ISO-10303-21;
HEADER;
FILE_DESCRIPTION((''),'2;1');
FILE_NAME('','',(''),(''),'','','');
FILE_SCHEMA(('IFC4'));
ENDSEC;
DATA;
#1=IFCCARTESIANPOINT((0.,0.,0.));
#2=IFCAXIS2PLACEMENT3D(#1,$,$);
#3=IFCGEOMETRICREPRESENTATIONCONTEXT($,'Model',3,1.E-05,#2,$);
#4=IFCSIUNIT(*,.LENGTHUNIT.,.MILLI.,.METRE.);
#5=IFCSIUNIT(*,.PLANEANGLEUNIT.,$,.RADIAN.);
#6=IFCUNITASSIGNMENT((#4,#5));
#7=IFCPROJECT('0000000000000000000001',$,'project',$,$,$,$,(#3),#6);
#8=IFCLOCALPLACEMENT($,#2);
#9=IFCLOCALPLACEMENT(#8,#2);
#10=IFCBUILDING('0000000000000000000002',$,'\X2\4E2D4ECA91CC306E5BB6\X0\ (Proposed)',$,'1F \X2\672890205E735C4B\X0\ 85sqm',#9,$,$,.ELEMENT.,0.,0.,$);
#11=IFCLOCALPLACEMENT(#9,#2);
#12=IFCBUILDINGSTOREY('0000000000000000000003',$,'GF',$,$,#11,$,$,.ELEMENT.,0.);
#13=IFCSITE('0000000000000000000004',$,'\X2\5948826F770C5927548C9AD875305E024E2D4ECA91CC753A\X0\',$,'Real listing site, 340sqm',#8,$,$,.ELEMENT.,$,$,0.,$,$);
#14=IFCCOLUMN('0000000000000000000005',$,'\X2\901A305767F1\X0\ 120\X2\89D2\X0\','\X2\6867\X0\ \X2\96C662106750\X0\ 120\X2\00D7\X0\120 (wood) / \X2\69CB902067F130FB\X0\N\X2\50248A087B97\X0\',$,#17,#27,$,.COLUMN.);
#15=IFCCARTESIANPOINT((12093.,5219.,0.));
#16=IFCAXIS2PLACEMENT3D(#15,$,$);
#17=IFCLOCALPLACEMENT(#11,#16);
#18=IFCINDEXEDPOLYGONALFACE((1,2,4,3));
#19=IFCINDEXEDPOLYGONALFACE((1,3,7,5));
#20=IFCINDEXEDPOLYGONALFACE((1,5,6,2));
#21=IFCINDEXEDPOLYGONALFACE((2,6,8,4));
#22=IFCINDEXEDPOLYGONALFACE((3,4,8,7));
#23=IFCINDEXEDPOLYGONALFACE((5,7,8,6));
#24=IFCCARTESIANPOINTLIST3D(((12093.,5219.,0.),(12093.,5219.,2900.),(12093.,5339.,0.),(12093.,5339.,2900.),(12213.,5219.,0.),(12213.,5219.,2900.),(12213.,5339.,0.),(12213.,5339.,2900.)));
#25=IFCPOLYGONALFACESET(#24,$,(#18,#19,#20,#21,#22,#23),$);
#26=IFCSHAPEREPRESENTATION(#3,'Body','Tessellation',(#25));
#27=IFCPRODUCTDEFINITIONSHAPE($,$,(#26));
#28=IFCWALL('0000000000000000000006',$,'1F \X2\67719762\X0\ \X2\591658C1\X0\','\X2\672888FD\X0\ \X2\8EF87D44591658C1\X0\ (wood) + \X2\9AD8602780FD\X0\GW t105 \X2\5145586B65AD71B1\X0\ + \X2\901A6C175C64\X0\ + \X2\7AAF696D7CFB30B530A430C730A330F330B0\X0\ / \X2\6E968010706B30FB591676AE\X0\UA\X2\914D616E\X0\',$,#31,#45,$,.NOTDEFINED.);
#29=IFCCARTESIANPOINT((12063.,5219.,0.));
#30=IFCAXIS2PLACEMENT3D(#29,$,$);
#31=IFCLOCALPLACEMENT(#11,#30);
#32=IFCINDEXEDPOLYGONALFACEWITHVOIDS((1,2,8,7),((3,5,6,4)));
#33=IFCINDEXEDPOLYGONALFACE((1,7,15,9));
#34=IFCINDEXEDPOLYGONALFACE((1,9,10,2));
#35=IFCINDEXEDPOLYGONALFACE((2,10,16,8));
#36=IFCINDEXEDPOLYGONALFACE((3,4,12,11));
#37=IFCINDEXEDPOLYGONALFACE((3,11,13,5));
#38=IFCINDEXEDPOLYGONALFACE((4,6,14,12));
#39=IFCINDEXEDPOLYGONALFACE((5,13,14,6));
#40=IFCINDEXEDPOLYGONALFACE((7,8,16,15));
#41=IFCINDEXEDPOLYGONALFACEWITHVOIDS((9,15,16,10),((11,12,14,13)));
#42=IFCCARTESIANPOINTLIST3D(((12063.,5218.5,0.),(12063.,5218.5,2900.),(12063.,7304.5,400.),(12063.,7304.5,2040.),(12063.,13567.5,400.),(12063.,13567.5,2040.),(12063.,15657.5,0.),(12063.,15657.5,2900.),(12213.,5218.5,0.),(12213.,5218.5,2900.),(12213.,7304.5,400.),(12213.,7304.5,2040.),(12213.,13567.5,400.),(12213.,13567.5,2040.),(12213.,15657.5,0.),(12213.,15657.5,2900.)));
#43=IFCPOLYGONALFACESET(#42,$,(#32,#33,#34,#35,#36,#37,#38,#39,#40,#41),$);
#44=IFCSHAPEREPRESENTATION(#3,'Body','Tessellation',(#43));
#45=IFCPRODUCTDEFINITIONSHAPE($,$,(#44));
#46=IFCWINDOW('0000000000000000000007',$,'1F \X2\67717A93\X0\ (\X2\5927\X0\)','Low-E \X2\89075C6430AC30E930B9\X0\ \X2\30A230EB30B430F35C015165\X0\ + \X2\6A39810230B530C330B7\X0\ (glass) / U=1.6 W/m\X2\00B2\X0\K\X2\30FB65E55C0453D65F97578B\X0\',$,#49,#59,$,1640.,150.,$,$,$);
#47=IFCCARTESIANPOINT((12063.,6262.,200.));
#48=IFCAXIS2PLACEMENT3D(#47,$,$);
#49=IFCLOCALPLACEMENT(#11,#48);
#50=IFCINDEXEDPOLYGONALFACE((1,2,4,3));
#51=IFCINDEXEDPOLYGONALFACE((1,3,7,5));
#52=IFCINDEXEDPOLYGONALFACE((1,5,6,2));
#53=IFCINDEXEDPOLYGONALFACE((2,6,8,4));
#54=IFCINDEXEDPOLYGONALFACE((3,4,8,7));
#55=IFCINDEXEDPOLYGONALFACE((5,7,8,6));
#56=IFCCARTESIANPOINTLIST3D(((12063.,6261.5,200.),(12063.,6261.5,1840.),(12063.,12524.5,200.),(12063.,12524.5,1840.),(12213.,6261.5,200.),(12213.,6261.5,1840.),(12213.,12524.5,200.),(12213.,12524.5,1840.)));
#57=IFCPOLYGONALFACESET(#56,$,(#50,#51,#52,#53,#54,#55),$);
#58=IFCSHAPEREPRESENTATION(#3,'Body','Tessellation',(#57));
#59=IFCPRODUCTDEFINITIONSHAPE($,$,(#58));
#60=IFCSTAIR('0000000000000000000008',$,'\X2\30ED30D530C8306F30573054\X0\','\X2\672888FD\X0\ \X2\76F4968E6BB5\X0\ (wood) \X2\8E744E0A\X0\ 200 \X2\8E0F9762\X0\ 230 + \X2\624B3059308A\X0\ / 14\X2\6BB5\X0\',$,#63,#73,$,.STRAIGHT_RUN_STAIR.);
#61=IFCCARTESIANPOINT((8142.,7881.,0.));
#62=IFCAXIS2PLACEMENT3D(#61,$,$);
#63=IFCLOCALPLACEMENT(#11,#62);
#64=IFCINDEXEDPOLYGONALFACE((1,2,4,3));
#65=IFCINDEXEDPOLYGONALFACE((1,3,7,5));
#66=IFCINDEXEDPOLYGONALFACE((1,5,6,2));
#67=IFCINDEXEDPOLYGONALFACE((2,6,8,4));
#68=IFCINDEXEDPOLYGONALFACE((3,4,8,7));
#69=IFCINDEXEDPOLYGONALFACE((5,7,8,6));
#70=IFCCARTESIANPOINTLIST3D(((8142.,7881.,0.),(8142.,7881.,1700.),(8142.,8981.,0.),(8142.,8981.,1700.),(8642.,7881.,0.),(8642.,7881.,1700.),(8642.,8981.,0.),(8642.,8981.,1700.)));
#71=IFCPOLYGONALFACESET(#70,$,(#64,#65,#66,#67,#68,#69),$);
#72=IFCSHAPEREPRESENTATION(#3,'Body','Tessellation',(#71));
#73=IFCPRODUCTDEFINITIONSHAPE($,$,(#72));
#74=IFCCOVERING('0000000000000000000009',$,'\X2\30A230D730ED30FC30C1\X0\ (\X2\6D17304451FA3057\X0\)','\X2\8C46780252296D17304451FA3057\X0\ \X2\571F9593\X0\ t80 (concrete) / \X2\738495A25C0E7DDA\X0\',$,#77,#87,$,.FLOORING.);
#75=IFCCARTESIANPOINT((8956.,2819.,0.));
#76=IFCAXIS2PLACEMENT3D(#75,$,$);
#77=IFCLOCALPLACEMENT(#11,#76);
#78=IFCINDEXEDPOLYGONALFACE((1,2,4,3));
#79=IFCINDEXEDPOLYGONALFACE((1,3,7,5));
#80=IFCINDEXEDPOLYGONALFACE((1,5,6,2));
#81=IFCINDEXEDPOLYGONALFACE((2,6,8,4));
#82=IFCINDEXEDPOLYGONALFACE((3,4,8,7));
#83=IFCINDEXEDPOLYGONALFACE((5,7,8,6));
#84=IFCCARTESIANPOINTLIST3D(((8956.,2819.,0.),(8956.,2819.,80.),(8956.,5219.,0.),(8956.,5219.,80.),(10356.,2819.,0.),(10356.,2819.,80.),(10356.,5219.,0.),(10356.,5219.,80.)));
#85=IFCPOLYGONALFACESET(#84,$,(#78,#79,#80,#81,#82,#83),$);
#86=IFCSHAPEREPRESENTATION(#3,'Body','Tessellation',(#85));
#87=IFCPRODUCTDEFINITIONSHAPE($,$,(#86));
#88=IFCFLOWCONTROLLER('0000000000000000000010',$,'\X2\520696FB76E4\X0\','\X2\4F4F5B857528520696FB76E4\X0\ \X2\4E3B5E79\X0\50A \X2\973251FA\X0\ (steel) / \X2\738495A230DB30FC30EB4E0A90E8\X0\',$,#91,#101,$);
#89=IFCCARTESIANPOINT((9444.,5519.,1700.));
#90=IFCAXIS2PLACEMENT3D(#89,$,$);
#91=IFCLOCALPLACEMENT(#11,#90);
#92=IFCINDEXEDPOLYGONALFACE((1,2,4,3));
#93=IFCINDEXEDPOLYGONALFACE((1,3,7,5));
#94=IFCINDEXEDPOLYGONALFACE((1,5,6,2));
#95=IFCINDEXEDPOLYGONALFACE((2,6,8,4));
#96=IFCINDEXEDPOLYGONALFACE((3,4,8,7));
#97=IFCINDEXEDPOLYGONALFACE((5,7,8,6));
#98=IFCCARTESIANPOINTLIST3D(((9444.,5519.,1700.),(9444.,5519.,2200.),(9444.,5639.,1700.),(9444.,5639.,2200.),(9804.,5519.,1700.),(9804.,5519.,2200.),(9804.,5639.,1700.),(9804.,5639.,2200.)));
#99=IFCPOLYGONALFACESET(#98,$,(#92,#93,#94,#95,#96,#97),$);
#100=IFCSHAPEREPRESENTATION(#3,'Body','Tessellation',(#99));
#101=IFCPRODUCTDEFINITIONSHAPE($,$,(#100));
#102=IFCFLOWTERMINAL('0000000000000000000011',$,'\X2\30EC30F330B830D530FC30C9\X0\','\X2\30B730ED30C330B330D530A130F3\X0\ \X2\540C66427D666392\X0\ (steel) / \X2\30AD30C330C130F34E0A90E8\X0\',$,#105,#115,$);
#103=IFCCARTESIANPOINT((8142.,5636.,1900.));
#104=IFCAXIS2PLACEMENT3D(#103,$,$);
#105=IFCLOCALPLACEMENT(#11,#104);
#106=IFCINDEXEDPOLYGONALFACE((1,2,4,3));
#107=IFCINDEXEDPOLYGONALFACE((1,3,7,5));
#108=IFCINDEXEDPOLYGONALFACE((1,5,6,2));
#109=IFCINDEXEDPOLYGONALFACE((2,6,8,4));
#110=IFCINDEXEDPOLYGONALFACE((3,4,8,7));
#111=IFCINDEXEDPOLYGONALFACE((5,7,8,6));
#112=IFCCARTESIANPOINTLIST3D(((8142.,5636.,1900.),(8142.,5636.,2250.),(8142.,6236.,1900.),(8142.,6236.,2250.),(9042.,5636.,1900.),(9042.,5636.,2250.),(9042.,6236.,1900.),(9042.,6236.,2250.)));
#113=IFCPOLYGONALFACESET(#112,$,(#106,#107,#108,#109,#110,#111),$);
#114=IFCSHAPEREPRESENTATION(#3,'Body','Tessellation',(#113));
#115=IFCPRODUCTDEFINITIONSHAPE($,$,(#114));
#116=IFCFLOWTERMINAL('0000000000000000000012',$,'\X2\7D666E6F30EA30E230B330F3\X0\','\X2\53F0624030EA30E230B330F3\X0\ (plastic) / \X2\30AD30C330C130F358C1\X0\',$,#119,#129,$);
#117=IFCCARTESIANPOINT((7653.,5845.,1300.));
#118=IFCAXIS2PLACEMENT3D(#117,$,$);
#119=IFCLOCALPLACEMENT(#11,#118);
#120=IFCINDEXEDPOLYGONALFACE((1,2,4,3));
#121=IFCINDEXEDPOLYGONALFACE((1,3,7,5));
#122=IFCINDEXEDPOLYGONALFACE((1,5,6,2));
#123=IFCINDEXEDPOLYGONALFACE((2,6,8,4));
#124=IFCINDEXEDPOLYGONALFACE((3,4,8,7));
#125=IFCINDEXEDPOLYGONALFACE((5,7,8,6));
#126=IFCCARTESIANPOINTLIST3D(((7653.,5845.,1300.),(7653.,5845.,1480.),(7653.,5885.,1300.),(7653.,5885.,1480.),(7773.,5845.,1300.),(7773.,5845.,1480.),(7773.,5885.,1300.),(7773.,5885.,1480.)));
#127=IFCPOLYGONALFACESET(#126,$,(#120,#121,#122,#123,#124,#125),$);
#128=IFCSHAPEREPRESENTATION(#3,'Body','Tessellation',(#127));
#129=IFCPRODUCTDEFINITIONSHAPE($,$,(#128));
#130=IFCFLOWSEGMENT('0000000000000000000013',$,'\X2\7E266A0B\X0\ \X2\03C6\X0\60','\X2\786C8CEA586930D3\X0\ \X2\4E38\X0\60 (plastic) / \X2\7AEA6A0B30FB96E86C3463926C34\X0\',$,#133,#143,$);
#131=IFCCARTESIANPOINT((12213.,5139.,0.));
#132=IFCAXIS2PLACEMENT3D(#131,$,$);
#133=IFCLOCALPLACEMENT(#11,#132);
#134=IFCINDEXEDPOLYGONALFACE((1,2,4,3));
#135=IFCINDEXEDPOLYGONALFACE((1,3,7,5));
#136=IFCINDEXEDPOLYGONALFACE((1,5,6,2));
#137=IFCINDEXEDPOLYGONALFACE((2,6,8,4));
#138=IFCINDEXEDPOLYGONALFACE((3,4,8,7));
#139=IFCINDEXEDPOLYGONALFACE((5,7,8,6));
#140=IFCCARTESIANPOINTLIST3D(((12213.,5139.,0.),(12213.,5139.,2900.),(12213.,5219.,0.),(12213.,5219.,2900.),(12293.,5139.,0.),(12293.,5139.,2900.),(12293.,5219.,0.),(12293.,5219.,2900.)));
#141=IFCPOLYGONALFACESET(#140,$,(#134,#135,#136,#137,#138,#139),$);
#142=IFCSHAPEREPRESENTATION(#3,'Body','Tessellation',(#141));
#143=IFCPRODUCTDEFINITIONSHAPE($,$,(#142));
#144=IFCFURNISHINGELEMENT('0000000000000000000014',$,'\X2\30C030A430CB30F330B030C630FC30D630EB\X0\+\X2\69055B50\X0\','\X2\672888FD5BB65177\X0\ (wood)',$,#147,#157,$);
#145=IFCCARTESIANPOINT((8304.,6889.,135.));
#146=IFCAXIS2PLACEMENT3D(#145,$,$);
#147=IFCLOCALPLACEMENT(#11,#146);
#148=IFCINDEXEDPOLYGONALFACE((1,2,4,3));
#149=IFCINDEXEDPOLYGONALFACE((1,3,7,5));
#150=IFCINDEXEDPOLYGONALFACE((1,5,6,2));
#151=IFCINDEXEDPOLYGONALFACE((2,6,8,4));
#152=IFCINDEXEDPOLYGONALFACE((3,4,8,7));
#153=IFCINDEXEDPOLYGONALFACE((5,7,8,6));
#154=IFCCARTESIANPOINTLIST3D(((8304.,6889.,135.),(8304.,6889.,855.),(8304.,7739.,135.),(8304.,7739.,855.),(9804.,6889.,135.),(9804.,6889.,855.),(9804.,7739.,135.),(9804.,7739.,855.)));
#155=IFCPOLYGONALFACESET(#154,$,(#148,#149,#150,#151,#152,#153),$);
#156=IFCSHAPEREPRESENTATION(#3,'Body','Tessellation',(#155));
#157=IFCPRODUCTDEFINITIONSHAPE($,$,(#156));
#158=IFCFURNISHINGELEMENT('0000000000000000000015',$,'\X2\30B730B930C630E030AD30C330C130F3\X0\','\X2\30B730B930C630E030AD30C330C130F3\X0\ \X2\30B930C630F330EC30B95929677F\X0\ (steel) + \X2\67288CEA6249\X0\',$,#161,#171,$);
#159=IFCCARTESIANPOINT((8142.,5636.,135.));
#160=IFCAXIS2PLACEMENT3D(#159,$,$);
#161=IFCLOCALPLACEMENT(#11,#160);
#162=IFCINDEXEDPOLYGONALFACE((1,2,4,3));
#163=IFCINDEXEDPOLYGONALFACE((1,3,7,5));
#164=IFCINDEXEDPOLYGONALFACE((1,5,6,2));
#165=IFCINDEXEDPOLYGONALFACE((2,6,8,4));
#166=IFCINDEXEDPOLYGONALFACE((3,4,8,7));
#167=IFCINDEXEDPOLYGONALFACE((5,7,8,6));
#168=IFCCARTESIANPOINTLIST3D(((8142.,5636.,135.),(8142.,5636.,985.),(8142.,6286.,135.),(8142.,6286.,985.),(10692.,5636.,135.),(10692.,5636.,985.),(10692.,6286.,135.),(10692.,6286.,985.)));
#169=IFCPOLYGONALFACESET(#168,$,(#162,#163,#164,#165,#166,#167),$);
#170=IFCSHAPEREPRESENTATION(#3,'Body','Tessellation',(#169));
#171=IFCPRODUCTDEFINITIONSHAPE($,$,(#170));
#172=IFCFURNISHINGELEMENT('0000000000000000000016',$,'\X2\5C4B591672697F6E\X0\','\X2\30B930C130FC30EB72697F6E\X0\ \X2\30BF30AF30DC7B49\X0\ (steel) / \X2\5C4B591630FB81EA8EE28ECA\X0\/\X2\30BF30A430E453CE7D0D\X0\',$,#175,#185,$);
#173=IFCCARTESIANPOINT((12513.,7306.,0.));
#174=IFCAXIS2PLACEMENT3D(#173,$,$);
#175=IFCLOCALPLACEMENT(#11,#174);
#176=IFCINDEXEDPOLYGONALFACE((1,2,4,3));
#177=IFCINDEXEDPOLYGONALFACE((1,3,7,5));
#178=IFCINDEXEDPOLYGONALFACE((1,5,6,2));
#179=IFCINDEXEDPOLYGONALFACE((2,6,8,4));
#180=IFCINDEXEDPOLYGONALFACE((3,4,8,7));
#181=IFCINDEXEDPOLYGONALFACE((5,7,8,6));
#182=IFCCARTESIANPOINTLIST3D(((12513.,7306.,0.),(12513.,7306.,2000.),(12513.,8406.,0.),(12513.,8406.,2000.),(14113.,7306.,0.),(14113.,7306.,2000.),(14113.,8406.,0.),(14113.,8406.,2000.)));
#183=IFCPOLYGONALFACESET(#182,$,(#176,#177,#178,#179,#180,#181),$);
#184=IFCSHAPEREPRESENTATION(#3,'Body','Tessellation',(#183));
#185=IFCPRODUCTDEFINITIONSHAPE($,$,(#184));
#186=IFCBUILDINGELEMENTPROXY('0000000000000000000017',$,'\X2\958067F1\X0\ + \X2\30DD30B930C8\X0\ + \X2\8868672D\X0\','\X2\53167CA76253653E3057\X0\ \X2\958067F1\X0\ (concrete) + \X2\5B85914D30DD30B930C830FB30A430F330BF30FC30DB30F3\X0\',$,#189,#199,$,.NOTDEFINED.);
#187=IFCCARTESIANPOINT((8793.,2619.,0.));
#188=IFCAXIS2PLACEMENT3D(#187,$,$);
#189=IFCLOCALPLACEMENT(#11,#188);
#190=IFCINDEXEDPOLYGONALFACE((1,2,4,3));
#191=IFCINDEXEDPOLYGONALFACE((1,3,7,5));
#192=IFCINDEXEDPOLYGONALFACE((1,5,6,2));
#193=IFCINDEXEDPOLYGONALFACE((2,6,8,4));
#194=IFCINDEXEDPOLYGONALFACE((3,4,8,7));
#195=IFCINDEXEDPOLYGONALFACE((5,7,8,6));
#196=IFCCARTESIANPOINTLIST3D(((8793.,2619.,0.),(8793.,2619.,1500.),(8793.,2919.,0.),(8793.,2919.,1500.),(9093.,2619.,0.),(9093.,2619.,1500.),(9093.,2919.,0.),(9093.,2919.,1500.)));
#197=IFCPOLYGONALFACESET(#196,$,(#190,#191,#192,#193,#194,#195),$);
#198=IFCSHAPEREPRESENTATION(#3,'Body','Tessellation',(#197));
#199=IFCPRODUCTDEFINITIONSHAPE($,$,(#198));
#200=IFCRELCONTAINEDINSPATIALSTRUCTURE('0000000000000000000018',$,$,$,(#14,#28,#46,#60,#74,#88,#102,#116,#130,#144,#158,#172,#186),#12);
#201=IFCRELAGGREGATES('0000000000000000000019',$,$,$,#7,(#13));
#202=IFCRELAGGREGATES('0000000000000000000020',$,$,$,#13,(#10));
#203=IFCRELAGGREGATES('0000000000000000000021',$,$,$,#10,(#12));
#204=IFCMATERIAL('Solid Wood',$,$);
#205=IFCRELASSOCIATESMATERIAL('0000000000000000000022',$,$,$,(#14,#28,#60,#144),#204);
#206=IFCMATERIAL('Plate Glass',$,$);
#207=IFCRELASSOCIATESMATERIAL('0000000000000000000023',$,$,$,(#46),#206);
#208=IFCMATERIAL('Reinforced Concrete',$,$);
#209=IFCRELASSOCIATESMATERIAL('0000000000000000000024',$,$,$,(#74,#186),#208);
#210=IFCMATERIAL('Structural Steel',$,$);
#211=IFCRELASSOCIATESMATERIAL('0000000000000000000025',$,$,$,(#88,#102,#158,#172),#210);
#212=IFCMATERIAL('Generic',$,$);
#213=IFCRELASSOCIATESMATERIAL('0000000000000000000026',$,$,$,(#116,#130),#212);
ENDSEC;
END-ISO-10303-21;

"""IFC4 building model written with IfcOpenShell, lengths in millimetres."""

from ifc_helpers import new_model, si_unit, frame, frame_2d, origin, place, context, project, spatial, rectangle, extrude, material, element, fill, save


model = new_model("IFC4")

# Units and contexts
model_context = context("Model", 3, precision=1e-05, world=origin())
ifc_project = project(units=[si_unit("LENGTHUNIT", "METRE", prefix="MILLI"), si_unit("PLANEANGLEUNIT", "RADIAN")], contexts=[model_context])

# Site, building, storey
site_placement = place(None, origin())
site = spatial("IfcSite", under=ifc_project, at=site_placement, Name="奈良県大和高田市中今里町", ObjectType="Real listing site, 340sqm", CompositionType="ELEMENT", RefElevation=0.0)
building_placement = place(site_placement, origin())
building = spatial("IfcBuilding", under=site, at=building_placement, Name="中今里の家 (Proposed)", ObjectType="1F 木造平屋 85sqm", CompositionType="ELEMENT", ElevationOfRefHeight=0.0, ElevationOfTerrain=0.0)
storey_placement = place(building_placement, origin())
storey = spatial("IfcBuildingStorey", under=building, at=storey_placement, Name="GF", CompositionType="ELEMENT", Elevation=0.0)

# Column
ifc_material_1 = material(Name="Solid Wood")
column_1_placement = place(storey_placement, frame((12093.0, 5219.0, 0.0)))
element("IfcColumn", 1, at=column_1_placement, inside=storey, material=ifc_material_1, Name="通し柱 120角", Description="桧 集成材 120×120 (wood) / 構造柱・N値計算", PredefinedType="COLUMN", context=model_context, shape_type="SweptSolid", body=[
    extrude(rectangle(XDim=120.0, YDim=120.0, at=frame_2d((60.0, 60.0))), frame((12093.0, 5219.0, 0.0)), (0.0, 0.0, 1.0), 2900.0),
])

# Wall, opening, window
wall_1_placement = place(storey_placement, frame((12063.0, 5219.0, 0.0)))
wall_1 = element("IfcWall", 2, at=wall_1_placement, inside=storey, material=ifc_material_1, Name="1F 東面 外壁", Description="木製 軸組外壁 (wood) + 高性能GW t105 充填断熱 + 通気層 + 窯業系サイディング / 準耐火・外皮UA配慮", PredefinedType="NOTDEFINED", context=model_context, shape_type="SweptSolid", body=[
    extrude(rectangle(XDim=150.0, YDim=10439.0, at=frame_2d((75.0, 5219.0))), frame((12063.0, 5219.0, 0.0)), (0.0, 0.0, 1.0), 2900.0),
])
opening_placement = place(storey_placement, frame((12063.0, 6262.0, 200.0)))
opening = element("IfcOpeningElement", 3, at=opening_placement, cuts=wall_1, PredefinedType="NOTDEFINED", context=model_context, shape_type="SweptSolid", body=[
    extrude(rectangle(XDim=150.0, YDim=6263.0, at=frame_2d((75.0, 3131.0))), frame((12063.0, 6262.0, 200.0)), (0.0, 0.0, 1.0), 1640.0),
])
ifc_material_2 = material(Name="Plate Glass")
window_placement = place(storey_placement, frame((12063.0, 6262.0, 200.0)))
window = element("IfcWindow", 4, at=window_placement, inside=storey, material=ifc_material_2, Name="1F 東窓 (大)", Description="Low-E 複層ガラス アルゴン封入 + 樹脂サッシ (glass) / U=1.6 W/m²K・日射取得型", OverallHeight=1640.0, OverallWidth=150.0, context=model_context, shape_type="SweptSolid", body=[
    extrude(rectangle(XDim=150.0, YDim=6263.0, at=frame_2d((75.0, 3131.0))), frame((12063.0, 6262.0, 200.0)), (0.0, 0.0, 1.0), 1640.0),
])
fill(opening, window)

# Stair
stair_placement = place(storey_placement, frame((8142.0, 7881.0, 0.0)))
element("IfcStair", 5, at=stair_placement, inside=storey, material=ifc_material_1, Name="ロフトはしご", Description="木製 直階段 (wood) 蹴上 200 踏面 230 + 手すり / 14段", PredefinedType="STRAIGHT_RUN_STAIR", context=model_context, shape_type="SweptSolid", body=[
    extrude(rectangle(XDim=500.0, YDim=1100.0, at=frame_2d((250.0, 550.0))), frame((8142.0, 7881.0, 0.0)), (0.0, 0.0, 1.0), 1700.0),
])

# Covering
ifc_material_3 = material(Name="Reinforced Concrete")
covering_placement = place(storey_placement, frame((8956.0, 2819.0, 0.0)))
element("IfcCovering", 6, at=covering_placement, inside=storey, material=ifc_material_3, Name="アプローチ (洗い出し)", Description="豆砂利洗い出し 土間 t80 (concrete) / 玄関導線", PredefinedType="FLOORING", context=model_context, shape_type="SweptSolid", body=[
    extrude(rectangle(XDim=1400.0, YDim=2400.0, at=frame_2d((700.0, 1200.0))), frame((8956.0, 2819.0, 0.0)), (0.0, 0.0, 1.0), 80.0),
])

# Flow controller
ifc_material_4 = material(Name="Structural Steel")
flow_controller_placement = place(storey_placement, frame((9444.0, 5519.0, 1700.0)))
element("IfcFlowController", 7, at=flow_controller_placement, inside=storey, material=ifc_material_4, Name="分電盤", Description="住宅用分電盤 主幹50A 露出 (steel) / 玄関ホール上部", context=model_context, shape_type="SweptSolid", body=[
    extrude(rectangle(XDim=360.0, YDim=120.0, at=frame_2d((180.0, 60.0))), frame((9444.0, 5519.0, 1700.0)), (0.0, 0.0, 1.0), 500.0),
])

# Flow terminals
flow_terminal_1_placement = place(storey_placement, frame((8142.0, 5636.0, 1900.0)))
element("IfcFlowTerminal", 8, at=flow_terminal_1_placement, inside=storey, material=ifc_material_4, Name="レンジフード", Description="シロッコファン 同時給排 (steel) / キッチン上部", context=model_context, shape_type="SweptSolid", body=[
    extrude(rectangle(XDim=900.0, YDim=600.0, at=frame_2d((450.0, 300.0))), frame((8142.0, 5636.0, 1900.0)), (0.0, 0.0, 1.0), 350.0),
])
ifc_material_5 = material(Name="Generic")
flow_terminal_2_placement = place(storey_placement, frame((7653.0, 5845.0, 1300.0)))
element("IfcFlowTerminal", 9, at=flow_terminal_2_placement, inside=storey, material=ifc_material_5, Name="給湯リモコン", Description="台所リモコン (plastic) / キッチン壁", context=model_context, shape_type="SweptSolid", body=[
    extrude(rectangle(XDim=120.0, YDim=40.0, at=frame_2d((60.0, 20.0))), frame((7653.0, 5845.0, 1300.0)), (0.0, 0.0, 1.0), 180.0),
])

# Flow segment
flow_segment_placement = place(storey_placement, frame((12213.0, 5139.0, 0.0)))
element("IfcFlowSegment", 10, at=flow_segment_placement, inside=storey, material=ifc_material_5, Name="縦樋 φ60", Description="硬質塩ビ 丸60 (plastic) / 竪樋・雨水排水", context=model_context, shape_type="SweptSolid", body=[
    extrude(rectangle(XDim=80.0, YDim=80.0, at=frame_2d((40.0, 40.0))), frame((12213.0, 5139.0, 0.0)), (0.0, 0.0, 1.0), 2900.0),
])

# Furnishing elements
furnishing_1_placement = place(storey_placement, frame((8304.0, 6889.0, 135.0)))
element("IfcFurnishingElement", 11, at=furnishing_1_placement, inside=storey, material=ifc_material_1, Name="ダイニングテーブル+椅子", Description="木製家具 (wood)", context=model_context, shape_type="SweptSolid", body=[
    extrude(rectangle(XDim=1500.0, YDim=850.0, at=frame_2d((750.0, 425.0))), frame((8304.0, 6889.0, 135.0)), (0.0, 0.0, 1.0), 720.0),
])
furnishing_2_placement = place(storey_placement, frame((8142.0, 5636.0, 135.0)))
element("IfcFurnishingElement", 12, at=furnishing_2_placement, inside=storey, material=ifc_material_4, Name="システムキッチン", Description="システムキッチン ステンレス天板 (steel) + 木質扉", context=model_context, shape_type="SweptSolid", body=[
    extrude(rectangle(XDim=2550.0, YDim=650.0, at=frame_2d((1275.0, 325.0))), frame((8142.0, 5636.0, 135.0)), (0.0, 0.0, 1.0), 850.0),
])
furnishing_3_placement = place(storey_placement, frame((12513.0, 7306.0, 0.0)))
element("IfcFurnishingElement", 13, at=furnishing_3_placement, inside=storey, material=ifc_material_4, Name="屋外物置", Description="スチール物置 タクボ等 (steel) / 屋外・自転車/タイヤ収納", context=model_context, shape_type="SweptSolid", body=[
    extrude(rectangle(XDim=1600.0, YDim=1100.0, at=frame_2d((800.0, 550.0))), frame((12513.0, 7306.0, 0.0)), (0.0, 0.0, 1.0), 2000.0),
])

# Building element proxy
proxy_placement = place(storey_placement, frame((8793.0, 2619.0, 0.0)))
element("IfcBuildingElementProxy", 14, at=proxy_placement, inside=storey, material=ifc_material_3, Name="門柱 + ポスト + 表札", Description="化粧打放し 門柱 (concrete) + 宅配ポスト・インターホン", PredefinedType="NOTDEFINED", context=model_context, shape_type="SweptSolid", body=[
    extrude(rectangle(XDim=300.0, YDim=300.0, at=frame_2d((150.0, 150.0))), frame((8793.0, 2619.0, 0.0)), (0.0, 0.0, 1.0), 1500.0),
])

save(model, "model.ifc")
